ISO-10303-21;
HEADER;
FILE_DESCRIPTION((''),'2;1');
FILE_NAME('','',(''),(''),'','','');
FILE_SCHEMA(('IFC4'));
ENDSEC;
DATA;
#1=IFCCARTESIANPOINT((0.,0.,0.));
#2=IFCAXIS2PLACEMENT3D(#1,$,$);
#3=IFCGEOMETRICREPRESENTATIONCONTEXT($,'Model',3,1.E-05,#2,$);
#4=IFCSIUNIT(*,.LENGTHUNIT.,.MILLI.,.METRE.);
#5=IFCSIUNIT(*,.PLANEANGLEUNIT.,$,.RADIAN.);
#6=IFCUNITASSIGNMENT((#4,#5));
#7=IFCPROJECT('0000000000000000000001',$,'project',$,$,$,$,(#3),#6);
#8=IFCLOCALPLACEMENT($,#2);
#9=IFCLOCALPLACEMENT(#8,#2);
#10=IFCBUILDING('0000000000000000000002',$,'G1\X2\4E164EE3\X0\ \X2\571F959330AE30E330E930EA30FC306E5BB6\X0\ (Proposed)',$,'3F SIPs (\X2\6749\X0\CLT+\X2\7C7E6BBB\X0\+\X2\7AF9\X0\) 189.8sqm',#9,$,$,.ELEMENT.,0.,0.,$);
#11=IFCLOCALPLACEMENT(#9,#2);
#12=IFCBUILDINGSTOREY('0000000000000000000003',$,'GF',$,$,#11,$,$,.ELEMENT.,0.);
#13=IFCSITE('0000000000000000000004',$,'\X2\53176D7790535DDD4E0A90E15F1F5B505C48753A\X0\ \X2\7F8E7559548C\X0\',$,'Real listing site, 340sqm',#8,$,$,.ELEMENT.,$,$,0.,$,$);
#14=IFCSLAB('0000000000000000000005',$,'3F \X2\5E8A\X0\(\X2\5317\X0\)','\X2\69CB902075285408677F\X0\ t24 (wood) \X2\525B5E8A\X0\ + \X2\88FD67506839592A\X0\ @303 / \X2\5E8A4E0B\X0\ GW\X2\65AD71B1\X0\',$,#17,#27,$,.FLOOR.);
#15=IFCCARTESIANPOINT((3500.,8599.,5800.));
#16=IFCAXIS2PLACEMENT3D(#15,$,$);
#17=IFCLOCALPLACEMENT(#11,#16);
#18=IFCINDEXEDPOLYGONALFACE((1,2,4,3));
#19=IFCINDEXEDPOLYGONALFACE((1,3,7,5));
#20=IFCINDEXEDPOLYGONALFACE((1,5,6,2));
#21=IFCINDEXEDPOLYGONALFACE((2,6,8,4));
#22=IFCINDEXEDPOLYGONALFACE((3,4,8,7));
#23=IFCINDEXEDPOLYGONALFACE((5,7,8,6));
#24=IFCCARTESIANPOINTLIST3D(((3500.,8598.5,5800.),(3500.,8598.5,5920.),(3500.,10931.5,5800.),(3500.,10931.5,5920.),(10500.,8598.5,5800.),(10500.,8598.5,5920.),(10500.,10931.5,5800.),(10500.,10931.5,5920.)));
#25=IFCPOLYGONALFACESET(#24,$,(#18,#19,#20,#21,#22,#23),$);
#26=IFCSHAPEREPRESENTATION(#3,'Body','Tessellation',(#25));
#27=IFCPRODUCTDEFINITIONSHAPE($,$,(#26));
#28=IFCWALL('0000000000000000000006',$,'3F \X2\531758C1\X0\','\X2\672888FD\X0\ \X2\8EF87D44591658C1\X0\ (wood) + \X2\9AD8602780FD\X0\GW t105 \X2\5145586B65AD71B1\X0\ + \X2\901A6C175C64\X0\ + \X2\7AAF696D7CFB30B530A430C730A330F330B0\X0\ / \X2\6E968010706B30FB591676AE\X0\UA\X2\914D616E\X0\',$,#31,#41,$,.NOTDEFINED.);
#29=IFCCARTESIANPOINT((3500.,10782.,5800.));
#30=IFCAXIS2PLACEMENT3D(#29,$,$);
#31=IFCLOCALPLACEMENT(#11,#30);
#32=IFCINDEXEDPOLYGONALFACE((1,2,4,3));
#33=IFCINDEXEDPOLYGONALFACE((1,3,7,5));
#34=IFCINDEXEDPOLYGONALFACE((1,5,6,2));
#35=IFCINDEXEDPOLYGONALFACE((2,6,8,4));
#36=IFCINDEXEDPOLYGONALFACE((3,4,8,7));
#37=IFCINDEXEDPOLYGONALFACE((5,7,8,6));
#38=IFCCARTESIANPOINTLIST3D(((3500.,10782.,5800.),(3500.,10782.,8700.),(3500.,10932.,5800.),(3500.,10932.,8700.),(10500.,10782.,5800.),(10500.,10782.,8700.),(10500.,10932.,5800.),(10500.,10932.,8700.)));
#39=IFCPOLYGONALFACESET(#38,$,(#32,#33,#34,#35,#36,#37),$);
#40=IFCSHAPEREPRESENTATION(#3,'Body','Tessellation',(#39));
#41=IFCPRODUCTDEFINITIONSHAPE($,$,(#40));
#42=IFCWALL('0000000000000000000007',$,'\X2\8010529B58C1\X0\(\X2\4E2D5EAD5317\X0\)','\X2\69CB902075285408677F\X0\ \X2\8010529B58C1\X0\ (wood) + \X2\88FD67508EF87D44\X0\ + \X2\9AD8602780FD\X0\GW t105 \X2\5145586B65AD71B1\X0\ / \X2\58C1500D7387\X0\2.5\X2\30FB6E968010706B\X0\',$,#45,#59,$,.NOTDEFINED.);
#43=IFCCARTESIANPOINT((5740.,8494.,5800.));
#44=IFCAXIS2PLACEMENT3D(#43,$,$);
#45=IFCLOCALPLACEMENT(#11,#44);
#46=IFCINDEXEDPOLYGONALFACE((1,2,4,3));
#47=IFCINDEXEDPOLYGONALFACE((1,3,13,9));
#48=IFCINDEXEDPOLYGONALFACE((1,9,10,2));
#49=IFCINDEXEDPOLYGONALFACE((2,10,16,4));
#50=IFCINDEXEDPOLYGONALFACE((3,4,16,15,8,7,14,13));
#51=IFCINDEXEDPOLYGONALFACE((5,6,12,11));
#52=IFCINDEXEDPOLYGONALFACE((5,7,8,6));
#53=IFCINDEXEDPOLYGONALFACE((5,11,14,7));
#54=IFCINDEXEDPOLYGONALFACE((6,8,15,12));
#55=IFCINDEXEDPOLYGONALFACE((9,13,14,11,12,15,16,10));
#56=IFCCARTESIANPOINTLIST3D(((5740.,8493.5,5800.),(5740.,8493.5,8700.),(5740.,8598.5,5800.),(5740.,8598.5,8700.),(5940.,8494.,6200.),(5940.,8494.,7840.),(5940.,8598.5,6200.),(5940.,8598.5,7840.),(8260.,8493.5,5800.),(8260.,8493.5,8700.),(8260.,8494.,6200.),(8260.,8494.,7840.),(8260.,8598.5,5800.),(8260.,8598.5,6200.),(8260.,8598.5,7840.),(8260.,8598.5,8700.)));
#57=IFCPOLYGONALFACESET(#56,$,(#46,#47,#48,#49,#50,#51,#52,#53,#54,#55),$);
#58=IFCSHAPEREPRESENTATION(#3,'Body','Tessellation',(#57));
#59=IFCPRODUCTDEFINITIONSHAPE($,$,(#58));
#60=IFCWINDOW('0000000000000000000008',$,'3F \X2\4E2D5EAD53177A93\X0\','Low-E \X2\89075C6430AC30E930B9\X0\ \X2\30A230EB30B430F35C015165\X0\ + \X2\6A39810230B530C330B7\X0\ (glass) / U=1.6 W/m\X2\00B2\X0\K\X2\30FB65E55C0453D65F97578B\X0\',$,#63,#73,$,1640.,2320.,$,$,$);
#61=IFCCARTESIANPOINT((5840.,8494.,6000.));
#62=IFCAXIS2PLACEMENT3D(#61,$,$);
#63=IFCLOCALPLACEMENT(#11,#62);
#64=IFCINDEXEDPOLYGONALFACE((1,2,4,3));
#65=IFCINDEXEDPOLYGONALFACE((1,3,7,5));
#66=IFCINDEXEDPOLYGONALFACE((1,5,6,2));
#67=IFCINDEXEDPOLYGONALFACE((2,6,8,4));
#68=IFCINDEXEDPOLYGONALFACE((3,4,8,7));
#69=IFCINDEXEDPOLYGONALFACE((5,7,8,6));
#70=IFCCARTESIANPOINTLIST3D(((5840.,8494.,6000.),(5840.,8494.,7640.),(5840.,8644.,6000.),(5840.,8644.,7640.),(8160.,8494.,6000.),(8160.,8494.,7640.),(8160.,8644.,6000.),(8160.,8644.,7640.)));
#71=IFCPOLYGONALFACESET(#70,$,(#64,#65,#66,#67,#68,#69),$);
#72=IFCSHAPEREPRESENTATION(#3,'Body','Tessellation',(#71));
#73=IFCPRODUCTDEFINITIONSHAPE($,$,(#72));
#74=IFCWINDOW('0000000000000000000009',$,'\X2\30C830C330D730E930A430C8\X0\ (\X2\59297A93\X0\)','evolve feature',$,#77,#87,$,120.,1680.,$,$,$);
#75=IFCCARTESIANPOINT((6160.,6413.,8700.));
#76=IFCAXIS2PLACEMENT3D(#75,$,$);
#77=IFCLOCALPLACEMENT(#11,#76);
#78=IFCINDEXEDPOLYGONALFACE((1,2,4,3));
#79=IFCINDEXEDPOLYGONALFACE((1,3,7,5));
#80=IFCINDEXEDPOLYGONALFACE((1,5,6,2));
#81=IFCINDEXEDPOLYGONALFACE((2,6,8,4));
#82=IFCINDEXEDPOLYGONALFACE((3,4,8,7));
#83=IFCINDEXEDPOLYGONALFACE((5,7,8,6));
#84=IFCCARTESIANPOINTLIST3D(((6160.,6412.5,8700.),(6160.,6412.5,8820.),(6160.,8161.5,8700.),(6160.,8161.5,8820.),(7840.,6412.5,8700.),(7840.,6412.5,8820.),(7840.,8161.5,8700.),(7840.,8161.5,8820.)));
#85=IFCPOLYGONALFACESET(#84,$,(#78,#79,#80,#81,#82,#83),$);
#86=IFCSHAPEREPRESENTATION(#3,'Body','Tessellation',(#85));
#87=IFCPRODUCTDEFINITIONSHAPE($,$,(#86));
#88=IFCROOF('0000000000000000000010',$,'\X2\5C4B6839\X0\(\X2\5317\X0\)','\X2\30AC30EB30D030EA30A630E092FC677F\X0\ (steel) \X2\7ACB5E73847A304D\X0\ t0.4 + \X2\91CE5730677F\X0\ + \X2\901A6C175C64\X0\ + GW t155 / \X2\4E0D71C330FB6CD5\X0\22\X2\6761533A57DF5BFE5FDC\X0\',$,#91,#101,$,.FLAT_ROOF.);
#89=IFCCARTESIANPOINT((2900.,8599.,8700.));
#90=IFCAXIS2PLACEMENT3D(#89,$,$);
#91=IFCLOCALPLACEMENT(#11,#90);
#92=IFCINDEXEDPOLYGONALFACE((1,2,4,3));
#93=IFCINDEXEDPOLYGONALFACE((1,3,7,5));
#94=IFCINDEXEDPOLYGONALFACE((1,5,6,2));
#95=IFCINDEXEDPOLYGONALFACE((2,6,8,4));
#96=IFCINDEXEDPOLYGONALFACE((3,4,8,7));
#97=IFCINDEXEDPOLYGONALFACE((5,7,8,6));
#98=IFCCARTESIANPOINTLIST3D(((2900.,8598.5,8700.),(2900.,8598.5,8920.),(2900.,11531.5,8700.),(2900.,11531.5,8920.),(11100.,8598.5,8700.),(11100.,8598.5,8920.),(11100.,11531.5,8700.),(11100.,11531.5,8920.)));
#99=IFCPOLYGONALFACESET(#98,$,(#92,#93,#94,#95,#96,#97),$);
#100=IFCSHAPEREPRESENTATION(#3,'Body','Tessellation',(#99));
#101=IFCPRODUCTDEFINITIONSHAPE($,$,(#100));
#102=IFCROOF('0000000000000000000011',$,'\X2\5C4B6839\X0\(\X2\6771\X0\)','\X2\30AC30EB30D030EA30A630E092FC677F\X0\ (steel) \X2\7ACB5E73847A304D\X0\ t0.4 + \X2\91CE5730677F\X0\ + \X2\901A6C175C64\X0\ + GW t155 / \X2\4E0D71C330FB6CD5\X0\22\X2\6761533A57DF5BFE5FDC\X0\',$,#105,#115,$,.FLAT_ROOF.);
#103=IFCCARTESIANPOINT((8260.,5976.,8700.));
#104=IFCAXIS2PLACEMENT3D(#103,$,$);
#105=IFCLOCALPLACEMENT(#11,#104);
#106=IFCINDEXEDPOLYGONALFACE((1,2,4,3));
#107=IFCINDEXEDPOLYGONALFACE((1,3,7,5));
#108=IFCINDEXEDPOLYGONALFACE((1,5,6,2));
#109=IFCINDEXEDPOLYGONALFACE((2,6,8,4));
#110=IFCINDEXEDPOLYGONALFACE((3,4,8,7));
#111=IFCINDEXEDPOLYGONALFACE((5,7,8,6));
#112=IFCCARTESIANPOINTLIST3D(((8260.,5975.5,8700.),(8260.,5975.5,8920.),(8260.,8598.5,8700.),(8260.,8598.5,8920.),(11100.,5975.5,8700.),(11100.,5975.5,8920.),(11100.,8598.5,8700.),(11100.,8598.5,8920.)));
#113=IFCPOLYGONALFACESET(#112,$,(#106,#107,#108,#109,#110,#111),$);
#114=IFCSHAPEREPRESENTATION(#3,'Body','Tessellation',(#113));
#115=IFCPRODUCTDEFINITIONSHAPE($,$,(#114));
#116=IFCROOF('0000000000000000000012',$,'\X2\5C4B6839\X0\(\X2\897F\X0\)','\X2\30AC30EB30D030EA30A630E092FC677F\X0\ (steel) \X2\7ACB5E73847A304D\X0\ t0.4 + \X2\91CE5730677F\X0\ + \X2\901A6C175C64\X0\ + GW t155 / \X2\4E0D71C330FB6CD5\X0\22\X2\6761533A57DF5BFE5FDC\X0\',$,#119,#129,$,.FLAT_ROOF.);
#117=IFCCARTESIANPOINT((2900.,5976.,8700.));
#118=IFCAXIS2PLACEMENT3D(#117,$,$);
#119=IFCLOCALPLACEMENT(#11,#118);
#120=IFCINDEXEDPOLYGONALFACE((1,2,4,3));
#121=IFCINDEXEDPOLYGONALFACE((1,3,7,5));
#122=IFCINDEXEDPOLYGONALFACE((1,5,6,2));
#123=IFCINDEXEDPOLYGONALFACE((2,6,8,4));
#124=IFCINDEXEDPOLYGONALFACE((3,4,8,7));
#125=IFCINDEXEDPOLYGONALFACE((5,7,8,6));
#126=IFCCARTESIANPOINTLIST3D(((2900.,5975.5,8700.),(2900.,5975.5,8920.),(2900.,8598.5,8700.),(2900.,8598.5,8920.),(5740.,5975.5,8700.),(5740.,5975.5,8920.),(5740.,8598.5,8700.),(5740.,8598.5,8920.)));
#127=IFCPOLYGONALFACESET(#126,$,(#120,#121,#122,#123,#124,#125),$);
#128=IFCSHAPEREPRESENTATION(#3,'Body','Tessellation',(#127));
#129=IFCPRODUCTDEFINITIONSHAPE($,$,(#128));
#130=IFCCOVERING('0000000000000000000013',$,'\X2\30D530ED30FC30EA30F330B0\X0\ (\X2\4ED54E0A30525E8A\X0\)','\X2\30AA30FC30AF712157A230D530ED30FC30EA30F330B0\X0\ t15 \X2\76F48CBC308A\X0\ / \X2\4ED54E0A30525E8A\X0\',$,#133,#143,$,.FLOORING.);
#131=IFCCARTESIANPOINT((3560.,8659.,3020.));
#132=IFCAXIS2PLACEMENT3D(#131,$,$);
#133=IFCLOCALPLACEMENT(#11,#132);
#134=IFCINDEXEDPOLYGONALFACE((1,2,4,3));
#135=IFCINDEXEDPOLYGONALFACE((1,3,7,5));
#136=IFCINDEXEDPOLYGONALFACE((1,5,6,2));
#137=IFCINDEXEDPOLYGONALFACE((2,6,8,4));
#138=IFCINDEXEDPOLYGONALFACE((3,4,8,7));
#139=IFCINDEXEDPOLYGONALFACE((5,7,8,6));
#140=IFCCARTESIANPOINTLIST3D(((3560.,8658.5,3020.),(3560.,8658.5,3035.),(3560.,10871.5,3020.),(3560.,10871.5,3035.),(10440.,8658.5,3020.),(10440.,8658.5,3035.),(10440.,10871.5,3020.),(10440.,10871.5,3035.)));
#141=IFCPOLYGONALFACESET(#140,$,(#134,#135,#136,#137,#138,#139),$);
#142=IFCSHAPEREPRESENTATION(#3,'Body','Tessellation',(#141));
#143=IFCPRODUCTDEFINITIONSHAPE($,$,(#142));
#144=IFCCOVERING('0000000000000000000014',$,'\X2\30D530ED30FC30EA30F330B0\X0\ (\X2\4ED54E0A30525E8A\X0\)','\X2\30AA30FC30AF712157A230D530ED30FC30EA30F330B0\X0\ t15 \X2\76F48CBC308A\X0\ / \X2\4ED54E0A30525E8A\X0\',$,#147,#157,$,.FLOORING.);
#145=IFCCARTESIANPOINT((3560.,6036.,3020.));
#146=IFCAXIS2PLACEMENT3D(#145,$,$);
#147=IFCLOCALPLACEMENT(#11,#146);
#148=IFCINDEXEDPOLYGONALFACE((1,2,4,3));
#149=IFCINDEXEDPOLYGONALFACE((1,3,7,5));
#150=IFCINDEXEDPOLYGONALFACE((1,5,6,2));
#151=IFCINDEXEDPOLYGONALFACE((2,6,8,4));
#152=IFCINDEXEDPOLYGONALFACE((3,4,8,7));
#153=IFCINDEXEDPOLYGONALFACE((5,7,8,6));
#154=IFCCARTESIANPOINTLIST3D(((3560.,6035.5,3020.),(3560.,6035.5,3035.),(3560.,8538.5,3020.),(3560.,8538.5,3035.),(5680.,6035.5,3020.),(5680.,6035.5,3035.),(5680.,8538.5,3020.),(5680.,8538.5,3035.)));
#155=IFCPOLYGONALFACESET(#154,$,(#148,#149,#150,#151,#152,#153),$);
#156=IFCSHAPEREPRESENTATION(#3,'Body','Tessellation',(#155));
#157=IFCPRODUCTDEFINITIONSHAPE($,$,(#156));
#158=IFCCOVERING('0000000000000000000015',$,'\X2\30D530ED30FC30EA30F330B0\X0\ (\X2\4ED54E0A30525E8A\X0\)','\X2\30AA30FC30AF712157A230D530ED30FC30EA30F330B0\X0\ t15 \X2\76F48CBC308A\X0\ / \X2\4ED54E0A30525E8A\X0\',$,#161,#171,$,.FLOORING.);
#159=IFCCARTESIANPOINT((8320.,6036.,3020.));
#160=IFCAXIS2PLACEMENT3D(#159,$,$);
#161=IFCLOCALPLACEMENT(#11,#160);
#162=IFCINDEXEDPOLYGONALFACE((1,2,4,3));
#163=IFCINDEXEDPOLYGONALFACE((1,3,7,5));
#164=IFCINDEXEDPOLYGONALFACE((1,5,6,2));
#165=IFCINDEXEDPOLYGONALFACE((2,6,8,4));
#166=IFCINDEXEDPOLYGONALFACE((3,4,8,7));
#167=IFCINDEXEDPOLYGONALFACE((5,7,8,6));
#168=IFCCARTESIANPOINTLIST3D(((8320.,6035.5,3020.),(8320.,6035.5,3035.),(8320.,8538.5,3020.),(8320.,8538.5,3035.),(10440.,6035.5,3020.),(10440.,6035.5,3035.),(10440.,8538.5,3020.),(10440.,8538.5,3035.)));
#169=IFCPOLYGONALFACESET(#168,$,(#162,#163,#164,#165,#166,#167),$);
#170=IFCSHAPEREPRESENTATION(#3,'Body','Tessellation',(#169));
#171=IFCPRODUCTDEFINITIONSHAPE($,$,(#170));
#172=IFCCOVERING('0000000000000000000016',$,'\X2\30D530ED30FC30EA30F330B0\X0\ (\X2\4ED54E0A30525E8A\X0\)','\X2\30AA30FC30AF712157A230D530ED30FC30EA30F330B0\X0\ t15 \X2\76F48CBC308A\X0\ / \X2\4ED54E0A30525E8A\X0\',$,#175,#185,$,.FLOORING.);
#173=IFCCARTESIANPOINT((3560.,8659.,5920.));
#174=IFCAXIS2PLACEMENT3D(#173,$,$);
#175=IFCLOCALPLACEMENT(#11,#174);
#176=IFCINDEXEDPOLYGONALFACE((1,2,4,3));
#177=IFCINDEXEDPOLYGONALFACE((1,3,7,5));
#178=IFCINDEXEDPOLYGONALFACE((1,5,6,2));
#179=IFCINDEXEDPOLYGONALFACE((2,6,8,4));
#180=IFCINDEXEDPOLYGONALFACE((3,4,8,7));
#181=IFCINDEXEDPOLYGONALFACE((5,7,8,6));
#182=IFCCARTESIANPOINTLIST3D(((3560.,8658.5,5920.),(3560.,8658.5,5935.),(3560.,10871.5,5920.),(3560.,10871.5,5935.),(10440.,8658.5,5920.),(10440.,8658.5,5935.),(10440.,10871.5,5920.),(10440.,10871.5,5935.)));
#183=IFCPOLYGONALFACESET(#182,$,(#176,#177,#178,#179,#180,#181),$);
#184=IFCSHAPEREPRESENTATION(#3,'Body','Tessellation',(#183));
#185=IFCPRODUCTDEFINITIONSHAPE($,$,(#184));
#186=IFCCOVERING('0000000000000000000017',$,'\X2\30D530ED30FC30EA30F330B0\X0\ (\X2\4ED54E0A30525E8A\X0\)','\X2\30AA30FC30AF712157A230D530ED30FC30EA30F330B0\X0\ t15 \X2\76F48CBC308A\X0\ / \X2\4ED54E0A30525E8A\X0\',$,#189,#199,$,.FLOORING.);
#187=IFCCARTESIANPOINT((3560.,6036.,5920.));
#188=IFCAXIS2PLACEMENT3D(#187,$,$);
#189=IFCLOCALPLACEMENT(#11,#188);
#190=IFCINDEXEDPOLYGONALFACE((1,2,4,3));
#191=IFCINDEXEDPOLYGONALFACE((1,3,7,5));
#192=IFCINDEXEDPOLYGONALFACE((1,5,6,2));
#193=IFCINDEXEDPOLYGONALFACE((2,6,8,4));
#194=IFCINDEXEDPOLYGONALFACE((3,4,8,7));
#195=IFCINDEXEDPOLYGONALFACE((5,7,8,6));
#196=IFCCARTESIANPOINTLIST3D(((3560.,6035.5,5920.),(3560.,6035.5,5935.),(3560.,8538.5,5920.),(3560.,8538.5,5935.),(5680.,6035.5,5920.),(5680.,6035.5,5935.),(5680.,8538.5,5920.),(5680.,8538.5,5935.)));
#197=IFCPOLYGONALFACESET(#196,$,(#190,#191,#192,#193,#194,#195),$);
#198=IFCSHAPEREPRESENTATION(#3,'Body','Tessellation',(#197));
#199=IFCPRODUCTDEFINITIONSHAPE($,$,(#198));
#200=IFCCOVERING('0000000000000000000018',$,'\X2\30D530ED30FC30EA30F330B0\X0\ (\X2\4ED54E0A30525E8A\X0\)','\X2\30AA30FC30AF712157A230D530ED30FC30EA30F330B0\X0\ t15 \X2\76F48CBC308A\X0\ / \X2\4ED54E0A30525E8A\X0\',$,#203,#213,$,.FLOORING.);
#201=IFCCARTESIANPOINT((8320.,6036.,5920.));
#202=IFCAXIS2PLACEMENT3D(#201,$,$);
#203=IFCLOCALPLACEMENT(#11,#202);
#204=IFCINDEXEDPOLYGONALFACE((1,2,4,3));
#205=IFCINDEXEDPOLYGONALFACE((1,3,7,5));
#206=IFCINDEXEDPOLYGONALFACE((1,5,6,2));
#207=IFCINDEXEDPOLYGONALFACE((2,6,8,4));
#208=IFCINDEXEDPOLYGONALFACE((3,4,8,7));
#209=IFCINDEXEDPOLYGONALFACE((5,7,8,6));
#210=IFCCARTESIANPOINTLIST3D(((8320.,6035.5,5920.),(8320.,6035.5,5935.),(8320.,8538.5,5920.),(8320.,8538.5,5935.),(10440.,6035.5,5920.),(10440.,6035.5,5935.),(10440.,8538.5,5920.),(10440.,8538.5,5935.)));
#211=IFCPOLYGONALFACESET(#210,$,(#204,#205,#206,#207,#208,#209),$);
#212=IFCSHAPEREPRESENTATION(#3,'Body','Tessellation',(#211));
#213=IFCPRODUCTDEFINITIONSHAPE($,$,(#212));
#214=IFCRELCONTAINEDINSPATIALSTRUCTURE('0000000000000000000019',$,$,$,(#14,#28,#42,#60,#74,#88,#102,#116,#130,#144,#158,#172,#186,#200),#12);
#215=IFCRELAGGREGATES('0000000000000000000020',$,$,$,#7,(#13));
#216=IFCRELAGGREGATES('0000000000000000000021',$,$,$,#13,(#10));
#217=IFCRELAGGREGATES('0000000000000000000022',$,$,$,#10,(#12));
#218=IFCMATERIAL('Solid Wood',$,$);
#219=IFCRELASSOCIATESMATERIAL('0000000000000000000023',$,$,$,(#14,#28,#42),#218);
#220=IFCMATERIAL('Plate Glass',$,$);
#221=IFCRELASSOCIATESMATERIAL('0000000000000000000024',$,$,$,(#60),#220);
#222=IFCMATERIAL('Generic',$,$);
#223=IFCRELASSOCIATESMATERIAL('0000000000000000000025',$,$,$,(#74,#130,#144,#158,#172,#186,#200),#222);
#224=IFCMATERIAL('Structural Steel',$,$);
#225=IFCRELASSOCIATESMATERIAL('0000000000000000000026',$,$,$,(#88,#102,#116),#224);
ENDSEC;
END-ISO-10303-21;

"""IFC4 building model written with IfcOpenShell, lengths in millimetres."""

from ifc_helpers import new_model, si_unit, frame, frame_2d, origin, place, context, project, spatial, rectangle, extrude, material, element, fill, save


model = new_model("IFC4")

# Units and contexts
model_context = context("Model", 3, precision=1e-05, world=origin())
ifc_project = project(units=[si_unit("LENGTHUNIT", "METRE", prefix="MILLI"), si_unit("PLANEANGLEUNIT", "RADIAN")], contexts=[model_context])

# Site, building, storey
site_placement = place(None, origin())
site = spatial("IfcSite", under=ifc_project, at=site_placement, Name="北海道川上郡弟子屈町 美留和", ObjectType="Real listing site, 340sqm", CompositionType="ELEMENT", RefElevation=0.0)
building_placement = place(site_placement, origin())
building = spatial("IfcBuilding", under=site, at=building_placement, Name="G1世代 土間ギャラリーの家 (Proposed)", ObjectType="3F SIPs (杉CLT+籾殻+竹) 189.8sqm", CompositionType="ELEMENT", ElevationOfRefHeight=0.0, ElevationOfTerrain=0.0)
storey_placement = place(building_placement, origin())
storey = spatial("IfcBuildingStorey", under=building, at=storey_placement, Name="GF", CompositionType="ELEMENT", Elevation=0.0)

# Slab
ifc_material_1 = material(Name="Solid Wood")
slab_placement = place(storey_placement, frame((3500.0, 8599.0, 5800.0)))
element("IfcSlab", 1, at=slab_placement, inside=storey, material=ifc_material_1, Name="3F 床(北)", Description="構造用合板 t24 (wood) 剛床 + 製材根太 @303 / 床下 GW断熱", PredefinedType="FLOOR", context=model_context, shape_type="SweptSolid", body=[
    extrude(rectangle(XDim=7000.0, YDim=2333.0, at=frame_2d((3500.0, 1166.0))), frame((3500.0, 8599.0, 5800.0)), (0.0, 0.0, 1.0), 120.0),
])

# Wall
wall_1_placement = place(storey_placement, frame((3500.0, 10782.0, 5800.0)))
element("IfcWall", 2, at=wall_1_placement, inside=storey, material=ifc_material_1, Name="3F 北壁", Description="木製 軸組外壁 (wood) + 高性能GW t105 充填断熱 + 通気層 + 窯業系サイディング / 準耐火・外皮UA配慮", PredefinedType="NOTDEFINED", context=model_context, shape_type="SweptSolid", body=[
    extrude(rectangle(XDim=7000.0, YDim=150.0, at=frame_2d((3500.0, 75.0))), frame((3500.0, 10782.0, 5800.0)), (0.0, 0.0, 1.0), 2900.0),
])

# Wall, opening, window
wall_2_placement = place(storey_placement, frame((5740.0, 8494.0, 5800.0)))
wall_2 = element("IfcWall", 3, at=wall_2_placement, inside=storey, material=ifc_material_1, Name="耐力壁(中庭北)", Description="構造用合板 耐力壁 (wood) + 製材軸組 + 高性能GW t105 充填断熱 / 壁倍率2.5・準耐火", PredefinedType="NOTDEFINED", context=model_context, shape_type="SweptSolid", body=[
    extrude(rectangle(XDim=2520.0, YDim=105.0, at=frame_2d((1260.0, 52.0))), frame((5740.0, 8494.0, 5800.0)), (0.0, 0.0, 1.0), 2900.0),
])
opening_placement = place(storey_placement, frame((5840.0, 8494.0, 6000.0)))
opening = element("IfcOpeningElement", 4, at=opening_placement, cuts=wall_2, PredefinedType="NOTDEFINED", context=model_context, shape_type="SweptSolid", body=[
    extrude(rectangle(XDim=2320.0, YDim=150.0, at=frame_2d((1160.0, 75.0))), frame((5840.0, 8494.0, 6000.0)), (0.0, 0.0, 1.0), 1640.0),
])
ifc_material_2 = material(Name="Plate Glass")
window_1_placement = place(storey_placement, frame((5840.0, 8494.0, 6000.0)))
window_1 = element("IfcWindow", 5, at=window_1_placement, inside=storey, material=ifc_material_2, Name="3F 中庭北窓", Description="Low-E 複層ガラス アルゴン封入 + 樹脂サッシ (glass) / U=1.6 W/m²K・日射取得型", OverallHeight=1640.0, OverallWidth=2320.0, context=model_context, shape_type="SweptSolid", body=[
    extrude(rectangle(XDim=2320.0, YDim=150.0, at=frame_2d((1160.0, 75.0))), frame((5840.0, 8494.0, 6000.0)), (0.0, 0.0, 1.0), 1640.0),
])
fill(opening, window_1)

# Window
ifc_material_3 = material(Name="Generic")
window_2_placement = place(storey_placement, frame((6160.0, 6413.0, 8700.0)))
element("IfcWindow", 6, at=window_2_placement, inside=storey, material=ifc_material_3, Name="トップライト (天窓)", Description="evolve feature", OverallHeight=120.0, OverallWidth=1680.0, context=model_context, shape_type="SweptSolid", body=[
    extrude(rectangle(XDim=1680.0, YDim=1749.0, at=frame_2d((840.0, 874.0))), frame((6160.0, 6413.0, 8700.0)), (0.0, 0.0, 1.0), 120.0),
])

# Roofs
ifc_material_4 = material(Name="Structural Steel")
roof_1_placement = place(storey_placement, frame((2900.0, 8599.0, 8700.0)))
element("IfcRoof", 7, at=roof_1_placement, inside=storey, material=ifc_material_4, Name="屋根(北)", Description="ガルバリウム鋼板 (steel) 立平葺き t0.4 + 野地板 + 通気層 + GW t155 / 不燃・法22条区域対応", PredefinedType="FLAT_ROOF", context=model_context, shape_type="SweptSolid", body=[
    extrude(rectangle(XDim=8200.0, YDim=2933.0, at=frame_2d((4100.0, 1466.0))), frame((2900.0, 8599.0, 8700.0)), (0.0, 0.0, 1.0), 220.0),
])
roof_2_placement = place(storey_placement, frame((8260.0, 5976.0, 8700.0)))
element("IfcRoof", 8, at=roof_2_placement, inside=storey, material=ifc_material_4, Name="屋根(東)", Description="ガルバリウム鋼板 (steel) 立平葺き t0.4 + 野地板 + 通気層 + GW t155 / 不燃・法22条区域対応", PredefinedType="FLAT_ROOF", context=model_context, shape_type="SweptSolid", body=[
    extrude(rectangle(XDim=2840.0, YDim=2623.0, at=frame_2d((1420.0, 1311.0))), frame((8260.0, 5976.0, 8700.0)), (0.0, 0.0, 1.0), 220.0),
])
roof_3_placement = place(storey_placement, frame((2900.0, 5976.0, 8700.0)))
element("IfcRoof", 9, at=roof_3_placement, inside=storey, material=ifc_material_4, Name="屋根(西)", Description="ガルバリウム鋼板 (steel) 立平葺き t0.4 + 野地板 + 通気層 + GW t155 / 不燃・法22条区域対応", PredefinedType="FLAT_ROOF", context=model_context, shape_type="SweptSolid", body=[
    extrude(rectangle(XDim=2840.0, YDim=2623.0, at=frame_2d((1420.0, 1311.0))), frame((2900.0, 5976.0, 8700.0)), (0.0, 0.0, 1.0), 220.0),
])

# Coverings
covering_1_placement = place(storey_placement, frame((3560.0, 8659.0, 3020.0)))
element("IfcCovering", 10, at=covering_1_placement, inside=storey, material=ifc_material_3, Name="フローリング (仕上げ床)", Description="オーク無垢フローリング t15 直貼り / 仕上げ床", PredefinedType="FLOORING", context=model_context, shape_type="SweptSolid", body=[
    extrude(rectangle(XDim=6880.0, YDim=2213.0, at=frame_2d((3440.0, 1106.0))), frame((3560.0, 8659.0, 3020.0)), (0.0, 0.0, 1.0), 15.0),
])
covering_2_placement = place(storey_placement, frame((3560.0, 6036.0, 3020.0)))
element("IfcCovering", 11, at=covering_2_placement, inside=storey, material=ifc_material_3, Name="フローリング (仕上げ床)", Description="オーク無垢フローリング t15 直貼り / 仕上げ床", PredefinedType="FLOORING", context=model_context, shape_type="SweptSolid", body=[
    extrude(rectangle(XDim=2120.0, YDim=2503.0, at=frame_2d((1060.0, 1251.0))), frame((3560.0, 6036.0, 3020.0)), (0.0, 0.0, 1.0), 15.0),
])
covering_3_placement = place(storey_placement, frame((8320.0, 6036.0, 3020.0)))
element("IfcCovering", 12, at=covering_3_placement, inside=storey, material=ifc_material_3, Name="フローリング (仕上げ床)", Description="オーク無垢フローリング t15 直貼り / 仕上げ床", PredefinedType="FLOORING", context=model_context, shape_type="SweptSolid", body=[
    extrude(rectangle(XDim=2120.0, YDim=2503.0, at=frame_2d((1060.0, 1251.0))), frame((8320.0, 6036.0, 3020.0)), (0.0, 0.0, 1.0), 15.0),
])
covering_4_placement = place(storey_placement, frame((3560.0, 8659.0, 5920.0)))
element("IfcCovering", 13, at=covering_4_placement, inside=storey, material=ifc_material_3, Name="フローリング (仕上げ床)", Description="オーク無垢フローリング t15 直貼り / 仕上げ床", PredefinedType="FLOORING", context=model_context, shape_type="SweptSolid", body=[
    extrude(rectangle(XDim=6880.0, YDim=2213.0, at=frame_2d((3440.0, 1106.0))), frame((3560.0, 8659.0, 5920.0)), (0.0, 0.0, 1.0), 15.0),
])
covering_5_placement = place(storey_placement, frame((3560.0, 6036.0, 5920.0)))
element("IfcCovering", 14, at=covering_5_placement, inside=storey, material=ifc_material_3, Name="フローリング (仕上げ床)", Description="オーク無垢フローリング t15 直貼り / 仕上げ床", PredefinedType="FLOORING", context=model_context, shape_type="SweptSolid", body=[
    extrude(rectangle(XDim=2120.0, YDim=2503.0, at=frame_2d((1060.0, 1251.0))), frame((3560.0, 6036.0, 5920.0)), (0.0, 0.0, 1.0), 15.0),
])
covering_6_placement = place(storey_placement, frame((8320.0, 6036.0, 5920.0)))
element("IfcCovering", 15, at=covering_6_placement, inside=storey, material=ifc_material_3, Name="フローリング (仕上げ床)", Description="オーク無垢フローリング t15 直貼り / 仕上げ床", PredefinedType="FLOORING", context=model_context, shape_type="SweptSolid", body=[
    extrude(rectangle(XDim=2120.0, YDim=2503.0, at=frame_2d((1060.0, 1251.0))), frame((8320.0, 6036.0, 5920.0)), (0.0, 0.0, 1.0), 15.0),
])

save(model, "model.ifc")
